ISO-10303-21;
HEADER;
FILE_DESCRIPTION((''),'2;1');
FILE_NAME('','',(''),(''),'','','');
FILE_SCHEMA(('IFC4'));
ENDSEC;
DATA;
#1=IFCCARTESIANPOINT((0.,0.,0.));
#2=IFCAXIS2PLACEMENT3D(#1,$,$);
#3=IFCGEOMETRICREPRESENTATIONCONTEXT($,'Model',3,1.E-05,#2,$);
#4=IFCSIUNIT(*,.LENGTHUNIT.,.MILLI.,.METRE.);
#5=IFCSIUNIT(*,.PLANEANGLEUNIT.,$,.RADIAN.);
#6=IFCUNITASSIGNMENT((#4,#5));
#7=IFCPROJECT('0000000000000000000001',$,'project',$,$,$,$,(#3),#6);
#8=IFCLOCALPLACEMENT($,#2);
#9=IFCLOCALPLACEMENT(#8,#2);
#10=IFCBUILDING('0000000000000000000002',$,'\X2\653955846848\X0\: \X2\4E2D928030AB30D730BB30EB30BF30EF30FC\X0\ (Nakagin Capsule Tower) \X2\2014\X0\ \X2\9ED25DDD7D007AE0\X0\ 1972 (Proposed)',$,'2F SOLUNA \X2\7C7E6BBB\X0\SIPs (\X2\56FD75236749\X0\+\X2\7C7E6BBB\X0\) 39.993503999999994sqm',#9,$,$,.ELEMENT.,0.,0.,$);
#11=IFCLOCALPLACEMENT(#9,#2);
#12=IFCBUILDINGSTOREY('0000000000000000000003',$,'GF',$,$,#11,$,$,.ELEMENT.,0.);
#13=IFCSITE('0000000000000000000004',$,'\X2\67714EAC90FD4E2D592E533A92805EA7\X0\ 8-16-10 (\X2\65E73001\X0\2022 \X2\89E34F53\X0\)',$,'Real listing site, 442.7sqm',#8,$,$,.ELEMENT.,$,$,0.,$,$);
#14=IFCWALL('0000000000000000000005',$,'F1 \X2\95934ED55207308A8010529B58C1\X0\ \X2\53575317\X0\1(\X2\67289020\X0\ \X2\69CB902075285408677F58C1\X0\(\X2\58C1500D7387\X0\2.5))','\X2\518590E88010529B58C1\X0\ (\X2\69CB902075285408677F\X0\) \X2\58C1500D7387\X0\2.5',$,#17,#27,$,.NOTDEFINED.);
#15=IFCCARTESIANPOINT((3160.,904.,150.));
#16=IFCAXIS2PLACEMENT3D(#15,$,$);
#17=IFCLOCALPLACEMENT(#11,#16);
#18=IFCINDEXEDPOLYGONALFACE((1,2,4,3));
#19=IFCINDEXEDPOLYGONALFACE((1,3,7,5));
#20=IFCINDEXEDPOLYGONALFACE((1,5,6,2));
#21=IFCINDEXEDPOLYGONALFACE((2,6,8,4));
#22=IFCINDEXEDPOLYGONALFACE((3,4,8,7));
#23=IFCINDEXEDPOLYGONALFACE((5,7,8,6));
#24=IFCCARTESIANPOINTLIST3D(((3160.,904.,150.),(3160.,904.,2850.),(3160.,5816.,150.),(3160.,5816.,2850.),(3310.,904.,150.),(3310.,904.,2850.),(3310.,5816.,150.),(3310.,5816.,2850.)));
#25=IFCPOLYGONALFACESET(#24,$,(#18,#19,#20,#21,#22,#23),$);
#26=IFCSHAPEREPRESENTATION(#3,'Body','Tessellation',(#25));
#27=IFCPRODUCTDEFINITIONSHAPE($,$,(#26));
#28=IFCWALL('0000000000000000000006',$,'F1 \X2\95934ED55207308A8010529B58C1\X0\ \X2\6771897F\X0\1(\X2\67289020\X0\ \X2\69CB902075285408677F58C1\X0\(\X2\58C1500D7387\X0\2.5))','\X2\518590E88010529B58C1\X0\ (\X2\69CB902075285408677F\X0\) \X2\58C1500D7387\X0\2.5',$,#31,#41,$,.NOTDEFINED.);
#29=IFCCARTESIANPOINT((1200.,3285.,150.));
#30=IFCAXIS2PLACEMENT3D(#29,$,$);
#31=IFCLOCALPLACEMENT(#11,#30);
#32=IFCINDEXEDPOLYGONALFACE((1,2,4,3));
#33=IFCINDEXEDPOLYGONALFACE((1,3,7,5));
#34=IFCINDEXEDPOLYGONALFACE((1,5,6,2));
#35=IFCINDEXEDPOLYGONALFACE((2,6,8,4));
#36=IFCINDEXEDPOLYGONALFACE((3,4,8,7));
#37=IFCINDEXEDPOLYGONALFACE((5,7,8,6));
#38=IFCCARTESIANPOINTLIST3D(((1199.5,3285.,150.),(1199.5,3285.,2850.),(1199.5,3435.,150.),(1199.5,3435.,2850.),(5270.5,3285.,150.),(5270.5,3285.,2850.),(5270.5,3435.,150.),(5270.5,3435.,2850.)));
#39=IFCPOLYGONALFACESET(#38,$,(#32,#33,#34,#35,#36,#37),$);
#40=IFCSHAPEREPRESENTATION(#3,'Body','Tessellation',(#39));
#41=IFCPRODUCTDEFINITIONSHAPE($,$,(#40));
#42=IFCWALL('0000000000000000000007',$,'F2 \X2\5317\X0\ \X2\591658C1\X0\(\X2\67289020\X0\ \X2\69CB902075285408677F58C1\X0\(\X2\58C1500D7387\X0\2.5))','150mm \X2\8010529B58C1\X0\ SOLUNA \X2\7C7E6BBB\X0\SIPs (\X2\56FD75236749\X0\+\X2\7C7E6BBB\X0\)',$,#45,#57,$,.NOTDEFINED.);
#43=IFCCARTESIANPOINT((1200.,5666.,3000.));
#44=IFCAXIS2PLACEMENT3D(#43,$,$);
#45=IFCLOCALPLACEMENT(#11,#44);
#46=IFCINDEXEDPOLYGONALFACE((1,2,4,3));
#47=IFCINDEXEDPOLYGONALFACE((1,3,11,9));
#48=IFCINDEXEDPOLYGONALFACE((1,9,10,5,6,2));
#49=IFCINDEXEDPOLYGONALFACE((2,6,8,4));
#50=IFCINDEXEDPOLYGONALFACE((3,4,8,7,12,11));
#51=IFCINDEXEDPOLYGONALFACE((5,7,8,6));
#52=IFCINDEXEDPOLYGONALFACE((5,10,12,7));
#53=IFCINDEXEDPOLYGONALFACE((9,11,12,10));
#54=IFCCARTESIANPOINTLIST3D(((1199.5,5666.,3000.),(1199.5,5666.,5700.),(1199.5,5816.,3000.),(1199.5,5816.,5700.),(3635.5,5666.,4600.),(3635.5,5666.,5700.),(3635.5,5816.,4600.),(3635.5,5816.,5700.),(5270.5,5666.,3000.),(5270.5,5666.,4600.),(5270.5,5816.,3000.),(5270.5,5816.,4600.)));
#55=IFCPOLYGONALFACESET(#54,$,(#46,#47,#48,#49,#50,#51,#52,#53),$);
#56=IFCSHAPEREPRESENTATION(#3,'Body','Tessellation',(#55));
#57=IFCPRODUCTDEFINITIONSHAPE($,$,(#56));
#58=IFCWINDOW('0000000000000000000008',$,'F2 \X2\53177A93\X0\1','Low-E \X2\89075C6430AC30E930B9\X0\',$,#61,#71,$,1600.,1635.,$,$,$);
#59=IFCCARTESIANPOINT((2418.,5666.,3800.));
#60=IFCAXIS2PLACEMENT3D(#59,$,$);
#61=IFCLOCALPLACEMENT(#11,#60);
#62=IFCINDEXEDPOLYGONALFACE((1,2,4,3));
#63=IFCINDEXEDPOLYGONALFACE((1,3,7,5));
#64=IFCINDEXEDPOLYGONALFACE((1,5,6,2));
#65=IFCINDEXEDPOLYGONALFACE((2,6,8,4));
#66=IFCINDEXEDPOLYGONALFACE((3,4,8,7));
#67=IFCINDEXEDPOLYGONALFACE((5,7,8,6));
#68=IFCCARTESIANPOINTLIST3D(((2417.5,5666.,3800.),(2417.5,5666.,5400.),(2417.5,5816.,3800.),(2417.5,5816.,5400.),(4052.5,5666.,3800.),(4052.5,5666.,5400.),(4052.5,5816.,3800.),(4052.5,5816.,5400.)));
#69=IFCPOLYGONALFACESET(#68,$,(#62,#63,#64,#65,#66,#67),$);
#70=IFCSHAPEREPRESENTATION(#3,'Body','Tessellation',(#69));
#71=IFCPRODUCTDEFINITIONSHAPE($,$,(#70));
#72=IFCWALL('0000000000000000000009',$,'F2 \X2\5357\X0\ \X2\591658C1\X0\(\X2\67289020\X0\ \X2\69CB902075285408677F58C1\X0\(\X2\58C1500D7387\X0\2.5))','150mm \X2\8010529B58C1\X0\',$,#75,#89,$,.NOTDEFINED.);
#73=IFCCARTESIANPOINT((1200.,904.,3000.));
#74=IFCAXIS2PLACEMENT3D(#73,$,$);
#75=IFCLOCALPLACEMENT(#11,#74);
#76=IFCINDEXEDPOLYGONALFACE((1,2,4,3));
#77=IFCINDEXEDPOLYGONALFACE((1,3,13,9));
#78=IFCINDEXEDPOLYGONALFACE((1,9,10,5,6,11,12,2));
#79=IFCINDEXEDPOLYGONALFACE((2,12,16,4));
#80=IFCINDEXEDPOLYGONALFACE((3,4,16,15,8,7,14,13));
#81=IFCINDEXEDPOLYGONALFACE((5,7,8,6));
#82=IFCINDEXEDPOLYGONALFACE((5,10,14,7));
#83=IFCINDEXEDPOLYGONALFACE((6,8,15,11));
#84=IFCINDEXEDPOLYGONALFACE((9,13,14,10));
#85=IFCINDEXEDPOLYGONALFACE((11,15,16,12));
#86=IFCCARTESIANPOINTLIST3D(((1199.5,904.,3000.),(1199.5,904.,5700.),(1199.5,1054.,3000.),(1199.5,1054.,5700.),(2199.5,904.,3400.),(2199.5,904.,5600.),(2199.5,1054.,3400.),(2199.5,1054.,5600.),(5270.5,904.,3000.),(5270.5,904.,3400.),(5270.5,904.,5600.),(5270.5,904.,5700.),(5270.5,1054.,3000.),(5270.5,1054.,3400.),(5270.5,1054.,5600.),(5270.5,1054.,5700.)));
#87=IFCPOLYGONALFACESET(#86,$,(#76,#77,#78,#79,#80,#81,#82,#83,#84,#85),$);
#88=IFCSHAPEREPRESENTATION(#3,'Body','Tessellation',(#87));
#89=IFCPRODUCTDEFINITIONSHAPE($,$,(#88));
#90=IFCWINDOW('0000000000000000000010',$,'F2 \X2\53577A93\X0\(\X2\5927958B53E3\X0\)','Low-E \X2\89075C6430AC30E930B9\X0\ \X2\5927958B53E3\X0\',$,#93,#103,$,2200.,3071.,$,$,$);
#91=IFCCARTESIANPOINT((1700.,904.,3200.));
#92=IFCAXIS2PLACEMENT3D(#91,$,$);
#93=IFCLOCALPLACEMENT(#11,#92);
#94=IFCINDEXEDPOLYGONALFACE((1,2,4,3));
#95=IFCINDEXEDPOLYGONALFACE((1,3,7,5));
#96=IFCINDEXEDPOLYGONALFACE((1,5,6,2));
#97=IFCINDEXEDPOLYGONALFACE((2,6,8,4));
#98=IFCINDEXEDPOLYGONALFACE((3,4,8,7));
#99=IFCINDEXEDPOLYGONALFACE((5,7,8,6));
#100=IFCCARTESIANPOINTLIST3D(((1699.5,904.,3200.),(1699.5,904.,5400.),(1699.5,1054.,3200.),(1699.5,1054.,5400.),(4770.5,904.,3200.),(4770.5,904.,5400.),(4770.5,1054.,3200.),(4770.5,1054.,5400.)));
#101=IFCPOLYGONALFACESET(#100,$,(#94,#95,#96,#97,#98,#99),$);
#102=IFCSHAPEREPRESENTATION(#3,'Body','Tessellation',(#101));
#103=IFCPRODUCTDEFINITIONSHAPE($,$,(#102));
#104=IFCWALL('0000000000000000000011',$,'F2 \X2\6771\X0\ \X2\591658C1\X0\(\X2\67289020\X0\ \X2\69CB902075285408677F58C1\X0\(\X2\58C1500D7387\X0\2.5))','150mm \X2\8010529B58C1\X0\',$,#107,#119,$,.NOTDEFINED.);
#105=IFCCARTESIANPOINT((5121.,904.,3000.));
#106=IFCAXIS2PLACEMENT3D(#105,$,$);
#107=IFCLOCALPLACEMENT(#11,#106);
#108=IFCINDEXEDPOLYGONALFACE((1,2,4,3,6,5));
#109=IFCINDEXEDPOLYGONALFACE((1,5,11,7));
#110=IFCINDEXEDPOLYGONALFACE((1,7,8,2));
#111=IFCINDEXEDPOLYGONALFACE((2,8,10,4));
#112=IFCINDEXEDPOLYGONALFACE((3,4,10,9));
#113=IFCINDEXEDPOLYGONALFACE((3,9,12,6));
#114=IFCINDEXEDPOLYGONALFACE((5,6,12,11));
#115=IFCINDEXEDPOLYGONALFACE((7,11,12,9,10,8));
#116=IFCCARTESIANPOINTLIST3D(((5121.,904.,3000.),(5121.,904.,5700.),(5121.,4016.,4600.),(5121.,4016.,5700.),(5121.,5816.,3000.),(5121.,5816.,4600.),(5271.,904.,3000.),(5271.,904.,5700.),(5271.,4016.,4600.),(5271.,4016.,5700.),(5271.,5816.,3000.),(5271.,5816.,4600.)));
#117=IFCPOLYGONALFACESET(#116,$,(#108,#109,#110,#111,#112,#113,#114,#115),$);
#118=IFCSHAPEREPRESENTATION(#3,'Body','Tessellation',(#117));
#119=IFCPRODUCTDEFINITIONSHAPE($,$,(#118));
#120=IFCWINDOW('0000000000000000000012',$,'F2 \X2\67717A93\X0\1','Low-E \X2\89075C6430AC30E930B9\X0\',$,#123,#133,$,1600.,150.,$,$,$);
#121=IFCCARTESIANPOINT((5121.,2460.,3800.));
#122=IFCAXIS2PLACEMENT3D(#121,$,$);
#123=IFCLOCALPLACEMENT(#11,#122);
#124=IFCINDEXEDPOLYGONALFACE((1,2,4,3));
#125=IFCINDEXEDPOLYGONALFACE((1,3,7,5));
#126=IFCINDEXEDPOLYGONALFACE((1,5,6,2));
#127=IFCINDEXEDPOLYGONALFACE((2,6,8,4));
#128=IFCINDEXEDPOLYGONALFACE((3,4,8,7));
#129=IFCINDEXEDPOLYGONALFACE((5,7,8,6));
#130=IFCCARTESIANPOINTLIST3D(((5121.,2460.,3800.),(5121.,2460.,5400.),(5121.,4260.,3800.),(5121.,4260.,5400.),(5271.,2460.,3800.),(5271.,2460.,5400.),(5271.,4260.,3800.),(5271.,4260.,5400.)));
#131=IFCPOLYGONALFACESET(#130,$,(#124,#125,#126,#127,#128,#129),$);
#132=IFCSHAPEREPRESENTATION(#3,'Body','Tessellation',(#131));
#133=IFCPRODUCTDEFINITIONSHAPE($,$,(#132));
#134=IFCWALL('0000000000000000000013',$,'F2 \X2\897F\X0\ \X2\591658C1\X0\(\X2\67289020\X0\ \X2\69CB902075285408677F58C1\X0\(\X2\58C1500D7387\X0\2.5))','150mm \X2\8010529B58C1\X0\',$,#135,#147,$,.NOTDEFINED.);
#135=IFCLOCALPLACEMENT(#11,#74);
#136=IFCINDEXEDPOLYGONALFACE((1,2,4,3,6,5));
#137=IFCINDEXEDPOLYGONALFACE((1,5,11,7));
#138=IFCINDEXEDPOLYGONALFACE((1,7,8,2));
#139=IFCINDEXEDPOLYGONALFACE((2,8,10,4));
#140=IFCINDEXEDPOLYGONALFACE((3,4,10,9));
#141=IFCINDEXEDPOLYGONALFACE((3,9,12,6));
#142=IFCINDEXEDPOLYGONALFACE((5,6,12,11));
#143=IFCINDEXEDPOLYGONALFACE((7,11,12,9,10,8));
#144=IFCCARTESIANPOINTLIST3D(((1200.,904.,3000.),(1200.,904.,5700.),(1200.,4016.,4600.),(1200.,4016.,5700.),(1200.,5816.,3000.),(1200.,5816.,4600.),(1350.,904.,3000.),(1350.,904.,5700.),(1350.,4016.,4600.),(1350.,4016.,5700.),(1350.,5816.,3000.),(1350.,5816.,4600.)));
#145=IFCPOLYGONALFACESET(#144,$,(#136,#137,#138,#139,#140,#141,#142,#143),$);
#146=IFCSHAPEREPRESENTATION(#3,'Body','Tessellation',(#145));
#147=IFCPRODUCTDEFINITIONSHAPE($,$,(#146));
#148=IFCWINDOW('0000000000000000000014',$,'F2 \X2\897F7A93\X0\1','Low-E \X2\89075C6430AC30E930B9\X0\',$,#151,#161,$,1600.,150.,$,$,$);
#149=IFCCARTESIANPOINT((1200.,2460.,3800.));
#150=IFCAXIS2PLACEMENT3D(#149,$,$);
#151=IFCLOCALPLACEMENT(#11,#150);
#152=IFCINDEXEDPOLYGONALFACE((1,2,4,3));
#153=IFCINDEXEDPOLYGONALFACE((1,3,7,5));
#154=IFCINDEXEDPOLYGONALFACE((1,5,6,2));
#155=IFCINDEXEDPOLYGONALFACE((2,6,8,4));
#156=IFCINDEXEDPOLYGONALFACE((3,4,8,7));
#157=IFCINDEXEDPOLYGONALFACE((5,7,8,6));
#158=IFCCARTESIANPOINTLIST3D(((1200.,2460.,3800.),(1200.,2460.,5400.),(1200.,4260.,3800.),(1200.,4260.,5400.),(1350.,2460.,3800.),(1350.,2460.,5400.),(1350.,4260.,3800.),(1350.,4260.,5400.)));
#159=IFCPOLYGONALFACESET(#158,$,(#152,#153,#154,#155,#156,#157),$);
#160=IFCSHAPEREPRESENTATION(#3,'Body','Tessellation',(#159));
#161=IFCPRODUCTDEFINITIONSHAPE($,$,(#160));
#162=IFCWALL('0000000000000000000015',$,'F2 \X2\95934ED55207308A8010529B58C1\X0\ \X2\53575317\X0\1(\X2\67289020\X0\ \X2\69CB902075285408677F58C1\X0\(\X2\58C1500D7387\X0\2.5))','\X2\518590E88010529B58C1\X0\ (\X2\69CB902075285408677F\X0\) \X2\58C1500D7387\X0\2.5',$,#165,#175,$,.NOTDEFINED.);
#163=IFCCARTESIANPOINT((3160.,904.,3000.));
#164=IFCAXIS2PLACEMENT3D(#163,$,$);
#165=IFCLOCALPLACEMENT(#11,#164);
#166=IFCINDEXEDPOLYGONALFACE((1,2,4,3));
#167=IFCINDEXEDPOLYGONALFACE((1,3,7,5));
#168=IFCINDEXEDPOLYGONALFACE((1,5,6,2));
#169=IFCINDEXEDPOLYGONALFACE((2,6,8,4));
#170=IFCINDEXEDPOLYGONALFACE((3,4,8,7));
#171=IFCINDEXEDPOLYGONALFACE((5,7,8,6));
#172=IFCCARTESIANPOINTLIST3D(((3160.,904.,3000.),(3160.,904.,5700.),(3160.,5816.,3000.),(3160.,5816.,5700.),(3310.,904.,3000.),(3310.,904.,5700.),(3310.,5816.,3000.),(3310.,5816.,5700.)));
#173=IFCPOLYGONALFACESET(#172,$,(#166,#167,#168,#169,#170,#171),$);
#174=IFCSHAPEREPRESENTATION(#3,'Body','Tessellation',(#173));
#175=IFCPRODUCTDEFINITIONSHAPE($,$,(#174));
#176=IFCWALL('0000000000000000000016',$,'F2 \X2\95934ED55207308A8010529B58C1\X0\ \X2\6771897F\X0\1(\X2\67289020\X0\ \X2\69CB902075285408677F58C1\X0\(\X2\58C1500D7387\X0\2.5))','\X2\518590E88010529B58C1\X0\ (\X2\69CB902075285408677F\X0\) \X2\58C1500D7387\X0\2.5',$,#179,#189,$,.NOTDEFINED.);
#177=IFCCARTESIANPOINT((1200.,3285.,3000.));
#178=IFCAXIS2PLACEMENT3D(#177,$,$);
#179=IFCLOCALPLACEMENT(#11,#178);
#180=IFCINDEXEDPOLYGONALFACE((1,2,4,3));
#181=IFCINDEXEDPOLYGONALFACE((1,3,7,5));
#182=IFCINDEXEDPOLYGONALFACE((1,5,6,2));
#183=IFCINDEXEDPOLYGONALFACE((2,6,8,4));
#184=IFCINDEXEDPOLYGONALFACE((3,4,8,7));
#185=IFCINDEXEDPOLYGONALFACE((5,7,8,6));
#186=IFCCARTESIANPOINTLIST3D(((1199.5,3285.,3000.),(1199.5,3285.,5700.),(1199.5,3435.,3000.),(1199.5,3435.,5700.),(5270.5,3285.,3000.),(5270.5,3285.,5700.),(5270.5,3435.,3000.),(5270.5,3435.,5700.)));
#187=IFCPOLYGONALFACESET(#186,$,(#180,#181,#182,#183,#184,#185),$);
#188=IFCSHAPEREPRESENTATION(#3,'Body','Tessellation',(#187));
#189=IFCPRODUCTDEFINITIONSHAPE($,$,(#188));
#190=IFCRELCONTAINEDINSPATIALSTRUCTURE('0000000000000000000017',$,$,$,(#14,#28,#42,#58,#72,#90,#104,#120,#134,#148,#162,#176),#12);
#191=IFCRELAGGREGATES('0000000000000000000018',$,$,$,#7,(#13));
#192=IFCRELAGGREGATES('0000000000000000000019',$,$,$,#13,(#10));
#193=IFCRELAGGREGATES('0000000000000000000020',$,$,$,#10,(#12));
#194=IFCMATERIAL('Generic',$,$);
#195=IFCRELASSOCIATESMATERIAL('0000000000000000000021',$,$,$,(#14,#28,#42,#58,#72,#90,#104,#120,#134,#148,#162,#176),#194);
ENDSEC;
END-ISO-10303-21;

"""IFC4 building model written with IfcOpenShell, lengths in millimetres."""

from ifc_helpers import new_model, si_unit, frame, frame_2d, origin, place, context, project, spatial, rectangle, extrude, material, element, fill, save


model = new_model("IFC4")

# Units and contexts
model_context = context("Model", 3, precision=1e-05, world=origin())
ifc_project = project(units=[si_unit("LENGTHUNIT", "METRE", prefix="MILLI"), si_unit("PLANEANGLEUNIT", "RADIAN")], contexts=[model_context])

# Site, building, storey
site_placement = place(None, origin())
site = spatial("IfcSite", under=ifc_project, at=site_placement, Name="東京都中央区銀座 8-16-10 (旧、2022 解体)", ObjectType="Real listing site, 442.7sqm", CompositionType="ELEMENT", RefElevation=0.0)
building_placement = place(site_placement, origin())
building = spatial("IfcBuilding", under=site, at=building_placement, Name="改善案: 中銀カプセルタワー (Nakagin Capsule Tower) — 黒川紀章 1972 (Proposed)", ObjectType="2F SOLUNA 籾殻SIPs (国産杉+籾殻) 39.993503999999994sqm", CompositionType="ELEMENT", ElevationOfRefHeight=0.0, ElevationOfTerrain=0.0)
storey_placement = place(building_placement, origin())
storey = spatial("IfcBuildingStorey", under=building, at=storey_placement, Name="GF", CompositionType="ELEMENT", Elevation=0.0)

# Shared definitions
ifc_material_1 = material(Name="Generic")

# Walls
wall_1_placement = place(storey_placement, frame((3160.0, 904.0, 150.0)))
element("IfcWall", 1, at=wall_1_placement, inside=storey, material=ifc_material_1, Name="F1 間仕切り耐力壁 南北1(木造 構造用合板壁(壁倍率2.5))", Description="内部耐力壁 (構造用合板) 壁倍率2.5", PredefinedType="NOTDEFINED", context=model_context, shape_type="SweptSolid", body=[
    extrude(rectangle(XDim=150.0, YDim=4912.0, at=frame_2d((75.0, 2456.0))), frame((3160.0, 904.0, 150.0)), (0.0, 0.0, 1.0), 2700.0),
])
wall_2_placement = place(storey_placement, frame((1200.0, 3285.0, 150.0)))
element("IfcWall", 2, at=wall_2_placement, inside=storey, material=ifc_material_1, Name="F1 間仕切り耐力壁 東西1(木造 構造用合板壁(壁倍率2.5))", Description="内部耐力壁 (構造用合板) 壁倍率2.5", PredefinedType="NOTDEFINED", context=model_context, shape_type="SweptSolid", body=[
    extrude(rectangle(XDim=4071.0, YDim=150.0, at=frame_2d((2035.0, 75.0))), frame((1200.0, 3285.0, 150.0)), (0.0, 0.0, 1.0), 2700.0),
])

# Walls, openings, windows
wall_3_placement = place(storey_placement, frame((1200.0, 5666.0, 3000.0)))
wall_3 = element("IfcWall", 3, at=wall_3_placement, inside=storey, material=ifc_material_1, Name="F2 北 外壁(木造 構造用合板壁(壁倍率2.5))", Description="150mm 耐力壁 SOLUNA 籾殻SIPs (国産杉+籾殻)", PredefinedType="NOTDEFINED", context=model_context, shape_type="SweptSolid", body=[
    extrude(rectangle(XDim=4071.0, YDim=150.0, at=frame_2d((2035.0, 75.0))), frame((1200.0, 5666.0, 3000.0)), (0.0, 0.0, 1.0), 2700.0),
])
opening_1_placement = place(storey_placement, frame((2418.0, 5666.0, 3800.0)))
opening_1 = element("IfcOpeningElement", 4, at=opening_1_placement, cuts=wall_3, PredefinedType="NOTDEFINED", context=model_context, shape_type="SweptSolid", body=[
    extrude(rectangle(XDim=1635.0, YDim=150.0, at=frame_2d((817.0, 75.0))), frame((2418.0, 5666.0, 3800.0)), (0.0, 0.0, 1.0), 1600.0),
])
window_1_placement = place(storey_placement, frame((2418.0, 5666.0, 3800.0)))
window_1 = element("IfcWindow", 5, at=window_1_placement, inside=storey, material=ifc_material_1, Name="F2 北窓1", Description="Low-E 複層ガラス", OverallHeight=1600.0, OverallWidth=1635.0, context=model_context, shape_type="SweptSolid", body=[
    extrude(rectangle(XDim=1635.0, YDim=150.0, at=frame_2d((817.0, 75.0))), frame((2418.0, 5666.0, 3800.0)), (0.0, 0.0, 1.0), 1600.0),
])
fill(opening_1, window_1)
wall_4_placement = place(storey_placement, frame((1200.0, 904.0, 3000.0)))
wall_4 = element("IfcWall", 6, at=wall_4_placement, inside=storey, material=ifc_material_1, Name="F2 南 外壁(木造 構造用合板壁(壁倍率2.5))", Description="150mm 耐力壁", PredefinedType="NOTDEFINED", context=model_context, shape_type="SweptSolid", body=[
    extrude(rectangle(XDim=4071.0, YDim=150.0, at=frame_2d((2035.0, 75.0))), frame((1200.0, 904.0, 3000.0)), (0.0, 0.0, 1.0), 2700.0),
])
opening_2_placement = place(storey_placement, frame((1700.0, 904.0, 3200.0)))
opening_2 = element("IfcOpeningElement", 7, at=opening_2_placement, cuts=wall_4, PredefinedType="NOTDEFINED", context=model_context, shape_type="SweptSolid", body=[
    extrude(rectangle(XDim=3071.0, YDim=150.0, at=frame_2d((1535.0, 75.0))), frame((1700.0, 904.0, 3200.0)), (0.0, 0.0, 1.0), 2200.0),
])
window_2_placement = place(storey_placement, frame((1700.0, 904.0, 3200.0)))
window_2 = element("IfcWindow", 8, at=window_2_placement, inside=storey, material=ifc_material_1, Name="F2 南窓(大開口)", Description="Low-E 複層ガラス 大開口", OverallHeight=2200.0, OverallWidth=3071.0, context=model_context, shape_type="SweptSolid", body=[
    extrude(rectangle(XDim=3071.0, YDim=150.0, at=frame_2d((1535.0, 75.0))), frame((1700.0, 904.0, 3200.0)), (0.0, 0.0, 1.0), 2200.0),
])
fill(opening_2, window_2)
wall_5_placement = place(storey_placement, frame((5121.0, 904.0, 3000.0)))
wall_5 = element("IfcWall", 9, at=wall_5_placement, inside=storey, material=ifc_material_1, Name="F2 東 外壁(木造 構造用合板壁(壁倍率2.5))", Description="150mm 耐力壁", PredefinedType="NOTDEFINED", context=model_context, shape_type="SweptSolid", body=[
    extrude(rectangle(XDim=150.0, YDim=4912.0, at=frame_2d((75.0, 2456.0))), frame((5121.0, 904.0, 3000.0)), (0.0, 0.0, 1.0), 2700.0),
])
opening_3_placement = place(storey_placement, frame((5121.0, 2460.0, 3800.0)))
opening_3 = element("IfcOpeningElement", 10, at=opening_3_placement, cuts=wall_5, PredefinedType="NOTDEFINED", context=model_context, shape_type="SweptSolid", body=[
    extrude(rectangle(XDim=150.0, YDim=1800.0, at=frame_2d((75.0, 900.0))), frame((5121.0, 2460.0, 3800.0)), (0.0, 0.0, 1.0), 1600.0),
])
window_3_placement = place(storey_placement, frame((5121.0, 2460.0, 3800.0)))
window_3 = element("IfcWindow", 11, at=window_3_placement, inside=storey, material=ifc_material_1, Name="F2 東窓1", Description="Low-E 複層ガラス", OverallHeight=1600.0, OverallWidth=150.0, context=model_context, shape_type="SweptSolid", body=[
    extrude(rectangle(XDim=150.0, YDim=1800.0, at=frame_2d((75.0, 900.0))), frame((5121.0, 2460.0, 3800.0)), (0.0, 0.0, 1.0), 1600.0),
])
fill(opening_3, window_3)
wall_6_placement = place(storey_placement, frame((1200.0, 904.0, 3000.0)))
wall_6 = element("IfcWall", 12, at=wall_6_placement, inside=storey, material=ifc_material_1, Name="F2 西 外壁(木造 構造用合板壁(壁倍率2.5))", Description="150mm 耐力壁", PredefinedType="NOTDEFINED", context=model_context, shape_type="SweptSolid", body=[
    extrude(rectangle(XDim=150.0, YDim=4912.0, at=frame_2d((75.0, 2456.0))), frame((1200.0, 904.0, 3000.0)), (0.0, 0.0, 1.0), 2700.0),
])
opening_4_placement = place(storey_placement, frame((1200.0, 2460.0, 3800.0)))
opening_4 = element("IfcOpeningElement", 13, at=opening_4_placement, cuts=wall_6, PredefinedType="NOTDEFINED", context=model_context, shape_type="SweptSolid", body=[
    extrude(rectangle(XDim=150.0, YDim=1800.0, at=frame_2d((75.0, 900.0))), frame((1200.0, 2460.0, 3800.0)), (0.0, 0.0, 1.0), 1600.0),
])
window_4_placement = place(storey_placement, frame((1200.0, 2460.0, 3800.0)))
window_4 = element("IfcWindow", 14, at=window_4_placement, inside=storey, material=ifc_material_1, Name="F2 西窓1", Description="Low-E 複層ガラス", OverallHeight=1600.0, OverallWidth=150.0, context=model_context, shape_type="SweptSolid", body=[
    extrude(rectangle(XDim=150.0, YDim=1800.0, at=frame_2d((75.0, 900.0))), frame((1200.0, 2460.0, 3800.0)), (0.0, 0.0, 1.0), 1600.0),
])
fill(opening_4, window_4)

# Walls
wall_7_placement = place(storey_placement, frame((3160.0, 904.0, 3000.0)))
element("IfcWall", 15, at=wall_7_placement, inside=storey, material=ifc_material_1, Name="F2 間仕切り耐力壁 南北1(木造 構造用合板壁(壁倍率2.5))", Description="内部耐力壁 (構造用合板) 壁倍率2.5", PredefinedType="NOTDEFINED", context=model_context, shape_type="SweptSolid", body=[
    extrude(rectangle(XDim=150.0, YDim=4912.0, at=frame_2d((75.0, 2456.0))), frame((3160.0, 904.0, 3000.0)), (0.0, 0.0, 1.0), 2700.0),
])
wall_8_placement = place(storey_placement, frame((1200.0, 3285.0, 3000.0)))
element("IfcWall", 16, at=wall_8_placement, inside=storey, material=ifc_material_1, Name="F2 間仕切り耐力壁 東西1(木造 構造用合板壁(壁倍率2.5))", Description="内部耐力壁 (構造用合板) 壁倍率2.5", PredefinedType="NOTDEFINED", context=model_context, shape_type="SweptSolid", body=[
    extrude(rectangle(XDim=4071.0, YDim=150.0, at=frame_2d((2035.0, 75.0))), frame((1200.0, 3285.0, 3000.0)), (0.0, 0.0, 1.0), 2700.0),
])

save(model, "model.ifc")
